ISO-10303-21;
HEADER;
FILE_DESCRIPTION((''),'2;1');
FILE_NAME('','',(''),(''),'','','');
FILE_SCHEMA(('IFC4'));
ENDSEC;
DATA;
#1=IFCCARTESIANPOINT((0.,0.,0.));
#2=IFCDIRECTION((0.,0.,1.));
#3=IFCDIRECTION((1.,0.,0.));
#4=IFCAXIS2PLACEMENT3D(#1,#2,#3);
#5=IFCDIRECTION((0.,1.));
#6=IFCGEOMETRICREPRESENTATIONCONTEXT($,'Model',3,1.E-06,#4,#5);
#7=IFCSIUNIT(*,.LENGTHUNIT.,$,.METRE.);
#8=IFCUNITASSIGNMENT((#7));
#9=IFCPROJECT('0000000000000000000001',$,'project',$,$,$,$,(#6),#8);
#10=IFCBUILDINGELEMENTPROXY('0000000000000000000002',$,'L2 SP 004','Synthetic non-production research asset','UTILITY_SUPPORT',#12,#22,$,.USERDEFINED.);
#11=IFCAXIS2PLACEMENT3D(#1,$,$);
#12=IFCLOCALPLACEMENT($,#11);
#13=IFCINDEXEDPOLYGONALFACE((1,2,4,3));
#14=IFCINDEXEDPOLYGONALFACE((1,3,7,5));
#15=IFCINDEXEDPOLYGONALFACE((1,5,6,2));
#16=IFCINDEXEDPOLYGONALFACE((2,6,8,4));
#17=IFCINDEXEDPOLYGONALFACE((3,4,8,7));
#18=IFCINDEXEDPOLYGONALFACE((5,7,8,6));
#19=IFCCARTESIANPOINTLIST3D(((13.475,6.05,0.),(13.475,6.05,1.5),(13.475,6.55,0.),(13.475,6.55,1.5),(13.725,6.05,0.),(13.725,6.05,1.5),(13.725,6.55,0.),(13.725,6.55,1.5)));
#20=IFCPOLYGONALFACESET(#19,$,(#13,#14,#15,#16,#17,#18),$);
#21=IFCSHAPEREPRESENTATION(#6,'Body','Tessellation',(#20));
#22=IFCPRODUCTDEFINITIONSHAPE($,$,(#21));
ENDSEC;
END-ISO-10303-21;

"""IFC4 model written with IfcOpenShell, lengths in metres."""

from ifc_helpers import new_model, si_unit, direction, frame, origin_with_axes, origin_2d_with_axis, place, context, project, rectangle, extrude, element, save


model = new_model("IFC4")

# Units and contexts
model_context = context("Model", 3, precision=1e-06, world=origin_with_axes(), true_north=direction((0.0, 1.0)))
ifc_project = project(units=[si_unit("LENGTHUNIT", "METRE")], contexts=[model_context])

# Building element proxy
proxy_placement = place(None, frame((13.6, 6.3, 0.0), z_axis=(0.0, 0.0, 1.0), x_axis=(1.0, 0.0, 0.0)))
element("IfcBuildingElementProxy", 1, at=proxy_placement, Name="L2 SP 004", Description="Synthetic non-production research asset", ObjectType="UTILITY_SUPPORT", PredefinedType="USERDEFINED", context=model_context, shape_type="SweptSolid", body=[
    extrude(rectangle(XDim=0.25, YDim=0.5, at=origin_2d_with_axis()), origin_with_axes(), (0.0, 0.0, 1.0), 1.5),
])

save(model, "model.ifc")
